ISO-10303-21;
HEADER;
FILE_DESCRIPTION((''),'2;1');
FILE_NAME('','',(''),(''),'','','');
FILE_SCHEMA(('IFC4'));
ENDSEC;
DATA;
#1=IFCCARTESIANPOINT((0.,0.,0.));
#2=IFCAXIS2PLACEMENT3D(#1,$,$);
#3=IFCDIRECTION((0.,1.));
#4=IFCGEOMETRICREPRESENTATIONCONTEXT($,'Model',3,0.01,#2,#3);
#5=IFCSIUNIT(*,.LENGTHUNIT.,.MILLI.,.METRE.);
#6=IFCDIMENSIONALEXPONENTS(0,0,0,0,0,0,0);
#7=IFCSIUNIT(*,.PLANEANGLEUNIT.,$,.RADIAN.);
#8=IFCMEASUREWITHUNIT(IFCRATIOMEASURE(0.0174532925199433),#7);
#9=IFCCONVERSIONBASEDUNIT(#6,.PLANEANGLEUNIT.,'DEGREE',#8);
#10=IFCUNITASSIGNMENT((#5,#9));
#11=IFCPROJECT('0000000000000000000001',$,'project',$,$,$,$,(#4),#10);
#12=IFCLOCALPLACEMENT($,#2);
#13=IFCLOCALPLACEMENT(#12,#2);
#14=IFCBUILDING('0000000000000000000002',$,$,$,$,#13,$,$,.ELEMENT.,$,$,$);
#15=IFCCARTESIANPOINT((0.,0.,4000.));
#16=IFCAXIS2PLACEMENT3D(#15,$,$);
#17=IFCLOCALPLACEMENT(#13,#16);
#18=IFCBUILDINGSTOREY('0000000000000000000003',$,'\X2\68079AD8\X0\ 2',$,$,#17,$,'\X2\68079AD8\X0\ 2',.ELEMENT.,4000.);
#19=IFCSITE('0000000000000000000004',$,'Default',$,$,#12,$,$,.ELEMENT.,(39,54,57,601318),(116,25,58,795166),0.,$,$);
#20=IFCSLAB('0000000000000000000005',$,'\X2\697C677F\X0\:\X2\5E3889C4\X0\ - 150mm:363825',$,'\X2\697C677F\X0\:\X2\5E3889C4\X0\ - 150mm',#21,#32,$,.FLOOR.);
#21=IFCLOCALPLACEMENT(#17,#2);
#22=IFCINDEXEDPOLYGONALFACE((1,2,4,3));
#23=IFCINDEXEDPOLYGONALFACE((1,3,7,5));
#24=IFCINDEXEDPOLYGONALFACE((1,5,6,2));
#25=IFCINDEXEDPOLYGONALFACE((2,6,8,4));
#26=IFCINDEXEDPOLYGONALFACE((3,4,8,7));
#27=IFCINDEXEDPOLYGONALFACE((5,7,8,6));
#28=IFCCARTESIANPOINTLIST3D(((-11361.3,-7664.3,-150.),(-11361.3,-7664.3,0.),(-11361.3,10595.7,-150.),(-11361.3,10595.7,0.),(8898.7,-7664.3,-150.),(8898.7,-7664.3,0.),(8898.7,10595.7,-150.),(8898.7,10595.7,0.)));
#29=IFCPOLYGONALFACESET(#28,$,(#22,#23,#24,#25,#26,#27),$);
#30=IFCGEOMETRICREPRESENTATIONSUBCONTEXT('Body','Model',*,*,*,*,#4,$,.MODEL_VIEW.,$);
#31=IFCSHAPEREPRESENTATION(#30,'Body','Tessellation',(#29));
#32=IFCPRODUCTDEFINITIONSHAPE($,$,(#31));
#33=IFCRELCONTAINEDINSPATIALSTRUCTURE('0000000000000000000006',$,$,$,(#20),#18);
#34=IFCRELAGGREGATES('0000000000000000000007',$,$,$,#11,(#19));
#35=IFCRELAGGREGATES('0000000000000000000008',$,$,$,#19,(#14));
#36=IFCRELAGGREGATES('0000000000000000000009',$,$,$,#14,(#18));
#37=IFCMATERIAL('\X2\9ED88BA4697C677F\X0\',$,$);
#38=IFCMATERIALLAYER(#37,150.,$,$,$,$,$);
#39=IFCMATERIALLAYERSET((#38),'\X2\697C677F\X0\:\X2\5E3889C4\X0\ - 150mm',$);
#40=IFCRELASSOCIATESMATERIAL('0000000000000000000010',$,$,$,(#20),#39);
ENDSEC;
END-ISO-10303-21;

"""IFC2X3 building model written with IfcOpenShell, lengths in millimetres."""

from ifc_helpers import new_model, entity, si_unit, converted_unit, direction, frame, frame_2d, origin, place, context, subcontext, project, spatial, rectangle, extrude, material, layer, layer_set, layer_usage, element, save


model = new_model("IFC2X3")

# Units and contexts
model_context = context("Model", 3, precision=0.01, world=origin(), true_north=direction((0.0, 1.0)))
body_context = subcontext(model_context, "Body", "Model", "MODEL_VIEW")
ifc_project = project(units=[si_unit("LENGTHUNIT", "METRE", prefix="MILLI"), converted_unit("PLANEANGLEUNIT", "DEGREE", entity("IfcRatioMeasure", 0.0174532925199433), si_unit("PLANEANGLEUNIT", "RADIAN"), dimensions=[0, 0, 0, 0, 0, 0, 0])], contexts=[model_context])

# Site, building, storey
site_placement = place(None, origin())
site = spatial("IfcSite", under=ifc_project, at=site_placement, Name="Default", CompositionType="ELEMENT", RefLatitude=(39, 54, 57, 601318), RefLongitude=(116, 25, 58, 795166), RefElevation=0.0)
building_placement = place(site_placement, origin())
building = spatial("IfcBuilding", under=site, at=building_placement, CompositionType="ELEMENT")
storey_placement = place(building_placement, frame((0.0, 0.0, 4000.0)))
storey = spatial("IfcBuildingStorey", under=building, at=storey_placement, Name="标高 2", LongName="标高 2", CompositionType="ELEMENT", Elevation=4000.0)

# Slab
ifc_material_1 = material(Name="默认楼板")
ifc_layer = layer(ifc_material_1, 150.0)
ifc_layer_set = layer_set([ifc_layer], Name="楼板:常规 - 150mm")
ifc_layer_usage = layer_usage(ifc_layer_set, "AXIS3", "POSITIVE", 0.0)
slab_placement = place(storey_placement, origin())
element("IfcSlab", 1, at=slab_placement, inside=storey, material=ifc_layer_usage, Name="楼板:常规 - 150mm:363825", ObjectType="楼板:常规 - 150mm", PredefinedType="FLOOR", context=body_context, shape_type="SweptSolid", body=[
    extrude(rectangle(XDim=18260.0, YDim=20260.0, at=frame_2d((0.0, 0.0), x_axis=(1.0, 0.0))), frame((-1231.3, 1465.7, 0.0), z_axis=(0.0, 0.0, -1.0), x_axis=(0.0, 1.0, 0.0)), (0.0, 0.0, 1.0), 150.0),
])

save(model, "model.ifc")
